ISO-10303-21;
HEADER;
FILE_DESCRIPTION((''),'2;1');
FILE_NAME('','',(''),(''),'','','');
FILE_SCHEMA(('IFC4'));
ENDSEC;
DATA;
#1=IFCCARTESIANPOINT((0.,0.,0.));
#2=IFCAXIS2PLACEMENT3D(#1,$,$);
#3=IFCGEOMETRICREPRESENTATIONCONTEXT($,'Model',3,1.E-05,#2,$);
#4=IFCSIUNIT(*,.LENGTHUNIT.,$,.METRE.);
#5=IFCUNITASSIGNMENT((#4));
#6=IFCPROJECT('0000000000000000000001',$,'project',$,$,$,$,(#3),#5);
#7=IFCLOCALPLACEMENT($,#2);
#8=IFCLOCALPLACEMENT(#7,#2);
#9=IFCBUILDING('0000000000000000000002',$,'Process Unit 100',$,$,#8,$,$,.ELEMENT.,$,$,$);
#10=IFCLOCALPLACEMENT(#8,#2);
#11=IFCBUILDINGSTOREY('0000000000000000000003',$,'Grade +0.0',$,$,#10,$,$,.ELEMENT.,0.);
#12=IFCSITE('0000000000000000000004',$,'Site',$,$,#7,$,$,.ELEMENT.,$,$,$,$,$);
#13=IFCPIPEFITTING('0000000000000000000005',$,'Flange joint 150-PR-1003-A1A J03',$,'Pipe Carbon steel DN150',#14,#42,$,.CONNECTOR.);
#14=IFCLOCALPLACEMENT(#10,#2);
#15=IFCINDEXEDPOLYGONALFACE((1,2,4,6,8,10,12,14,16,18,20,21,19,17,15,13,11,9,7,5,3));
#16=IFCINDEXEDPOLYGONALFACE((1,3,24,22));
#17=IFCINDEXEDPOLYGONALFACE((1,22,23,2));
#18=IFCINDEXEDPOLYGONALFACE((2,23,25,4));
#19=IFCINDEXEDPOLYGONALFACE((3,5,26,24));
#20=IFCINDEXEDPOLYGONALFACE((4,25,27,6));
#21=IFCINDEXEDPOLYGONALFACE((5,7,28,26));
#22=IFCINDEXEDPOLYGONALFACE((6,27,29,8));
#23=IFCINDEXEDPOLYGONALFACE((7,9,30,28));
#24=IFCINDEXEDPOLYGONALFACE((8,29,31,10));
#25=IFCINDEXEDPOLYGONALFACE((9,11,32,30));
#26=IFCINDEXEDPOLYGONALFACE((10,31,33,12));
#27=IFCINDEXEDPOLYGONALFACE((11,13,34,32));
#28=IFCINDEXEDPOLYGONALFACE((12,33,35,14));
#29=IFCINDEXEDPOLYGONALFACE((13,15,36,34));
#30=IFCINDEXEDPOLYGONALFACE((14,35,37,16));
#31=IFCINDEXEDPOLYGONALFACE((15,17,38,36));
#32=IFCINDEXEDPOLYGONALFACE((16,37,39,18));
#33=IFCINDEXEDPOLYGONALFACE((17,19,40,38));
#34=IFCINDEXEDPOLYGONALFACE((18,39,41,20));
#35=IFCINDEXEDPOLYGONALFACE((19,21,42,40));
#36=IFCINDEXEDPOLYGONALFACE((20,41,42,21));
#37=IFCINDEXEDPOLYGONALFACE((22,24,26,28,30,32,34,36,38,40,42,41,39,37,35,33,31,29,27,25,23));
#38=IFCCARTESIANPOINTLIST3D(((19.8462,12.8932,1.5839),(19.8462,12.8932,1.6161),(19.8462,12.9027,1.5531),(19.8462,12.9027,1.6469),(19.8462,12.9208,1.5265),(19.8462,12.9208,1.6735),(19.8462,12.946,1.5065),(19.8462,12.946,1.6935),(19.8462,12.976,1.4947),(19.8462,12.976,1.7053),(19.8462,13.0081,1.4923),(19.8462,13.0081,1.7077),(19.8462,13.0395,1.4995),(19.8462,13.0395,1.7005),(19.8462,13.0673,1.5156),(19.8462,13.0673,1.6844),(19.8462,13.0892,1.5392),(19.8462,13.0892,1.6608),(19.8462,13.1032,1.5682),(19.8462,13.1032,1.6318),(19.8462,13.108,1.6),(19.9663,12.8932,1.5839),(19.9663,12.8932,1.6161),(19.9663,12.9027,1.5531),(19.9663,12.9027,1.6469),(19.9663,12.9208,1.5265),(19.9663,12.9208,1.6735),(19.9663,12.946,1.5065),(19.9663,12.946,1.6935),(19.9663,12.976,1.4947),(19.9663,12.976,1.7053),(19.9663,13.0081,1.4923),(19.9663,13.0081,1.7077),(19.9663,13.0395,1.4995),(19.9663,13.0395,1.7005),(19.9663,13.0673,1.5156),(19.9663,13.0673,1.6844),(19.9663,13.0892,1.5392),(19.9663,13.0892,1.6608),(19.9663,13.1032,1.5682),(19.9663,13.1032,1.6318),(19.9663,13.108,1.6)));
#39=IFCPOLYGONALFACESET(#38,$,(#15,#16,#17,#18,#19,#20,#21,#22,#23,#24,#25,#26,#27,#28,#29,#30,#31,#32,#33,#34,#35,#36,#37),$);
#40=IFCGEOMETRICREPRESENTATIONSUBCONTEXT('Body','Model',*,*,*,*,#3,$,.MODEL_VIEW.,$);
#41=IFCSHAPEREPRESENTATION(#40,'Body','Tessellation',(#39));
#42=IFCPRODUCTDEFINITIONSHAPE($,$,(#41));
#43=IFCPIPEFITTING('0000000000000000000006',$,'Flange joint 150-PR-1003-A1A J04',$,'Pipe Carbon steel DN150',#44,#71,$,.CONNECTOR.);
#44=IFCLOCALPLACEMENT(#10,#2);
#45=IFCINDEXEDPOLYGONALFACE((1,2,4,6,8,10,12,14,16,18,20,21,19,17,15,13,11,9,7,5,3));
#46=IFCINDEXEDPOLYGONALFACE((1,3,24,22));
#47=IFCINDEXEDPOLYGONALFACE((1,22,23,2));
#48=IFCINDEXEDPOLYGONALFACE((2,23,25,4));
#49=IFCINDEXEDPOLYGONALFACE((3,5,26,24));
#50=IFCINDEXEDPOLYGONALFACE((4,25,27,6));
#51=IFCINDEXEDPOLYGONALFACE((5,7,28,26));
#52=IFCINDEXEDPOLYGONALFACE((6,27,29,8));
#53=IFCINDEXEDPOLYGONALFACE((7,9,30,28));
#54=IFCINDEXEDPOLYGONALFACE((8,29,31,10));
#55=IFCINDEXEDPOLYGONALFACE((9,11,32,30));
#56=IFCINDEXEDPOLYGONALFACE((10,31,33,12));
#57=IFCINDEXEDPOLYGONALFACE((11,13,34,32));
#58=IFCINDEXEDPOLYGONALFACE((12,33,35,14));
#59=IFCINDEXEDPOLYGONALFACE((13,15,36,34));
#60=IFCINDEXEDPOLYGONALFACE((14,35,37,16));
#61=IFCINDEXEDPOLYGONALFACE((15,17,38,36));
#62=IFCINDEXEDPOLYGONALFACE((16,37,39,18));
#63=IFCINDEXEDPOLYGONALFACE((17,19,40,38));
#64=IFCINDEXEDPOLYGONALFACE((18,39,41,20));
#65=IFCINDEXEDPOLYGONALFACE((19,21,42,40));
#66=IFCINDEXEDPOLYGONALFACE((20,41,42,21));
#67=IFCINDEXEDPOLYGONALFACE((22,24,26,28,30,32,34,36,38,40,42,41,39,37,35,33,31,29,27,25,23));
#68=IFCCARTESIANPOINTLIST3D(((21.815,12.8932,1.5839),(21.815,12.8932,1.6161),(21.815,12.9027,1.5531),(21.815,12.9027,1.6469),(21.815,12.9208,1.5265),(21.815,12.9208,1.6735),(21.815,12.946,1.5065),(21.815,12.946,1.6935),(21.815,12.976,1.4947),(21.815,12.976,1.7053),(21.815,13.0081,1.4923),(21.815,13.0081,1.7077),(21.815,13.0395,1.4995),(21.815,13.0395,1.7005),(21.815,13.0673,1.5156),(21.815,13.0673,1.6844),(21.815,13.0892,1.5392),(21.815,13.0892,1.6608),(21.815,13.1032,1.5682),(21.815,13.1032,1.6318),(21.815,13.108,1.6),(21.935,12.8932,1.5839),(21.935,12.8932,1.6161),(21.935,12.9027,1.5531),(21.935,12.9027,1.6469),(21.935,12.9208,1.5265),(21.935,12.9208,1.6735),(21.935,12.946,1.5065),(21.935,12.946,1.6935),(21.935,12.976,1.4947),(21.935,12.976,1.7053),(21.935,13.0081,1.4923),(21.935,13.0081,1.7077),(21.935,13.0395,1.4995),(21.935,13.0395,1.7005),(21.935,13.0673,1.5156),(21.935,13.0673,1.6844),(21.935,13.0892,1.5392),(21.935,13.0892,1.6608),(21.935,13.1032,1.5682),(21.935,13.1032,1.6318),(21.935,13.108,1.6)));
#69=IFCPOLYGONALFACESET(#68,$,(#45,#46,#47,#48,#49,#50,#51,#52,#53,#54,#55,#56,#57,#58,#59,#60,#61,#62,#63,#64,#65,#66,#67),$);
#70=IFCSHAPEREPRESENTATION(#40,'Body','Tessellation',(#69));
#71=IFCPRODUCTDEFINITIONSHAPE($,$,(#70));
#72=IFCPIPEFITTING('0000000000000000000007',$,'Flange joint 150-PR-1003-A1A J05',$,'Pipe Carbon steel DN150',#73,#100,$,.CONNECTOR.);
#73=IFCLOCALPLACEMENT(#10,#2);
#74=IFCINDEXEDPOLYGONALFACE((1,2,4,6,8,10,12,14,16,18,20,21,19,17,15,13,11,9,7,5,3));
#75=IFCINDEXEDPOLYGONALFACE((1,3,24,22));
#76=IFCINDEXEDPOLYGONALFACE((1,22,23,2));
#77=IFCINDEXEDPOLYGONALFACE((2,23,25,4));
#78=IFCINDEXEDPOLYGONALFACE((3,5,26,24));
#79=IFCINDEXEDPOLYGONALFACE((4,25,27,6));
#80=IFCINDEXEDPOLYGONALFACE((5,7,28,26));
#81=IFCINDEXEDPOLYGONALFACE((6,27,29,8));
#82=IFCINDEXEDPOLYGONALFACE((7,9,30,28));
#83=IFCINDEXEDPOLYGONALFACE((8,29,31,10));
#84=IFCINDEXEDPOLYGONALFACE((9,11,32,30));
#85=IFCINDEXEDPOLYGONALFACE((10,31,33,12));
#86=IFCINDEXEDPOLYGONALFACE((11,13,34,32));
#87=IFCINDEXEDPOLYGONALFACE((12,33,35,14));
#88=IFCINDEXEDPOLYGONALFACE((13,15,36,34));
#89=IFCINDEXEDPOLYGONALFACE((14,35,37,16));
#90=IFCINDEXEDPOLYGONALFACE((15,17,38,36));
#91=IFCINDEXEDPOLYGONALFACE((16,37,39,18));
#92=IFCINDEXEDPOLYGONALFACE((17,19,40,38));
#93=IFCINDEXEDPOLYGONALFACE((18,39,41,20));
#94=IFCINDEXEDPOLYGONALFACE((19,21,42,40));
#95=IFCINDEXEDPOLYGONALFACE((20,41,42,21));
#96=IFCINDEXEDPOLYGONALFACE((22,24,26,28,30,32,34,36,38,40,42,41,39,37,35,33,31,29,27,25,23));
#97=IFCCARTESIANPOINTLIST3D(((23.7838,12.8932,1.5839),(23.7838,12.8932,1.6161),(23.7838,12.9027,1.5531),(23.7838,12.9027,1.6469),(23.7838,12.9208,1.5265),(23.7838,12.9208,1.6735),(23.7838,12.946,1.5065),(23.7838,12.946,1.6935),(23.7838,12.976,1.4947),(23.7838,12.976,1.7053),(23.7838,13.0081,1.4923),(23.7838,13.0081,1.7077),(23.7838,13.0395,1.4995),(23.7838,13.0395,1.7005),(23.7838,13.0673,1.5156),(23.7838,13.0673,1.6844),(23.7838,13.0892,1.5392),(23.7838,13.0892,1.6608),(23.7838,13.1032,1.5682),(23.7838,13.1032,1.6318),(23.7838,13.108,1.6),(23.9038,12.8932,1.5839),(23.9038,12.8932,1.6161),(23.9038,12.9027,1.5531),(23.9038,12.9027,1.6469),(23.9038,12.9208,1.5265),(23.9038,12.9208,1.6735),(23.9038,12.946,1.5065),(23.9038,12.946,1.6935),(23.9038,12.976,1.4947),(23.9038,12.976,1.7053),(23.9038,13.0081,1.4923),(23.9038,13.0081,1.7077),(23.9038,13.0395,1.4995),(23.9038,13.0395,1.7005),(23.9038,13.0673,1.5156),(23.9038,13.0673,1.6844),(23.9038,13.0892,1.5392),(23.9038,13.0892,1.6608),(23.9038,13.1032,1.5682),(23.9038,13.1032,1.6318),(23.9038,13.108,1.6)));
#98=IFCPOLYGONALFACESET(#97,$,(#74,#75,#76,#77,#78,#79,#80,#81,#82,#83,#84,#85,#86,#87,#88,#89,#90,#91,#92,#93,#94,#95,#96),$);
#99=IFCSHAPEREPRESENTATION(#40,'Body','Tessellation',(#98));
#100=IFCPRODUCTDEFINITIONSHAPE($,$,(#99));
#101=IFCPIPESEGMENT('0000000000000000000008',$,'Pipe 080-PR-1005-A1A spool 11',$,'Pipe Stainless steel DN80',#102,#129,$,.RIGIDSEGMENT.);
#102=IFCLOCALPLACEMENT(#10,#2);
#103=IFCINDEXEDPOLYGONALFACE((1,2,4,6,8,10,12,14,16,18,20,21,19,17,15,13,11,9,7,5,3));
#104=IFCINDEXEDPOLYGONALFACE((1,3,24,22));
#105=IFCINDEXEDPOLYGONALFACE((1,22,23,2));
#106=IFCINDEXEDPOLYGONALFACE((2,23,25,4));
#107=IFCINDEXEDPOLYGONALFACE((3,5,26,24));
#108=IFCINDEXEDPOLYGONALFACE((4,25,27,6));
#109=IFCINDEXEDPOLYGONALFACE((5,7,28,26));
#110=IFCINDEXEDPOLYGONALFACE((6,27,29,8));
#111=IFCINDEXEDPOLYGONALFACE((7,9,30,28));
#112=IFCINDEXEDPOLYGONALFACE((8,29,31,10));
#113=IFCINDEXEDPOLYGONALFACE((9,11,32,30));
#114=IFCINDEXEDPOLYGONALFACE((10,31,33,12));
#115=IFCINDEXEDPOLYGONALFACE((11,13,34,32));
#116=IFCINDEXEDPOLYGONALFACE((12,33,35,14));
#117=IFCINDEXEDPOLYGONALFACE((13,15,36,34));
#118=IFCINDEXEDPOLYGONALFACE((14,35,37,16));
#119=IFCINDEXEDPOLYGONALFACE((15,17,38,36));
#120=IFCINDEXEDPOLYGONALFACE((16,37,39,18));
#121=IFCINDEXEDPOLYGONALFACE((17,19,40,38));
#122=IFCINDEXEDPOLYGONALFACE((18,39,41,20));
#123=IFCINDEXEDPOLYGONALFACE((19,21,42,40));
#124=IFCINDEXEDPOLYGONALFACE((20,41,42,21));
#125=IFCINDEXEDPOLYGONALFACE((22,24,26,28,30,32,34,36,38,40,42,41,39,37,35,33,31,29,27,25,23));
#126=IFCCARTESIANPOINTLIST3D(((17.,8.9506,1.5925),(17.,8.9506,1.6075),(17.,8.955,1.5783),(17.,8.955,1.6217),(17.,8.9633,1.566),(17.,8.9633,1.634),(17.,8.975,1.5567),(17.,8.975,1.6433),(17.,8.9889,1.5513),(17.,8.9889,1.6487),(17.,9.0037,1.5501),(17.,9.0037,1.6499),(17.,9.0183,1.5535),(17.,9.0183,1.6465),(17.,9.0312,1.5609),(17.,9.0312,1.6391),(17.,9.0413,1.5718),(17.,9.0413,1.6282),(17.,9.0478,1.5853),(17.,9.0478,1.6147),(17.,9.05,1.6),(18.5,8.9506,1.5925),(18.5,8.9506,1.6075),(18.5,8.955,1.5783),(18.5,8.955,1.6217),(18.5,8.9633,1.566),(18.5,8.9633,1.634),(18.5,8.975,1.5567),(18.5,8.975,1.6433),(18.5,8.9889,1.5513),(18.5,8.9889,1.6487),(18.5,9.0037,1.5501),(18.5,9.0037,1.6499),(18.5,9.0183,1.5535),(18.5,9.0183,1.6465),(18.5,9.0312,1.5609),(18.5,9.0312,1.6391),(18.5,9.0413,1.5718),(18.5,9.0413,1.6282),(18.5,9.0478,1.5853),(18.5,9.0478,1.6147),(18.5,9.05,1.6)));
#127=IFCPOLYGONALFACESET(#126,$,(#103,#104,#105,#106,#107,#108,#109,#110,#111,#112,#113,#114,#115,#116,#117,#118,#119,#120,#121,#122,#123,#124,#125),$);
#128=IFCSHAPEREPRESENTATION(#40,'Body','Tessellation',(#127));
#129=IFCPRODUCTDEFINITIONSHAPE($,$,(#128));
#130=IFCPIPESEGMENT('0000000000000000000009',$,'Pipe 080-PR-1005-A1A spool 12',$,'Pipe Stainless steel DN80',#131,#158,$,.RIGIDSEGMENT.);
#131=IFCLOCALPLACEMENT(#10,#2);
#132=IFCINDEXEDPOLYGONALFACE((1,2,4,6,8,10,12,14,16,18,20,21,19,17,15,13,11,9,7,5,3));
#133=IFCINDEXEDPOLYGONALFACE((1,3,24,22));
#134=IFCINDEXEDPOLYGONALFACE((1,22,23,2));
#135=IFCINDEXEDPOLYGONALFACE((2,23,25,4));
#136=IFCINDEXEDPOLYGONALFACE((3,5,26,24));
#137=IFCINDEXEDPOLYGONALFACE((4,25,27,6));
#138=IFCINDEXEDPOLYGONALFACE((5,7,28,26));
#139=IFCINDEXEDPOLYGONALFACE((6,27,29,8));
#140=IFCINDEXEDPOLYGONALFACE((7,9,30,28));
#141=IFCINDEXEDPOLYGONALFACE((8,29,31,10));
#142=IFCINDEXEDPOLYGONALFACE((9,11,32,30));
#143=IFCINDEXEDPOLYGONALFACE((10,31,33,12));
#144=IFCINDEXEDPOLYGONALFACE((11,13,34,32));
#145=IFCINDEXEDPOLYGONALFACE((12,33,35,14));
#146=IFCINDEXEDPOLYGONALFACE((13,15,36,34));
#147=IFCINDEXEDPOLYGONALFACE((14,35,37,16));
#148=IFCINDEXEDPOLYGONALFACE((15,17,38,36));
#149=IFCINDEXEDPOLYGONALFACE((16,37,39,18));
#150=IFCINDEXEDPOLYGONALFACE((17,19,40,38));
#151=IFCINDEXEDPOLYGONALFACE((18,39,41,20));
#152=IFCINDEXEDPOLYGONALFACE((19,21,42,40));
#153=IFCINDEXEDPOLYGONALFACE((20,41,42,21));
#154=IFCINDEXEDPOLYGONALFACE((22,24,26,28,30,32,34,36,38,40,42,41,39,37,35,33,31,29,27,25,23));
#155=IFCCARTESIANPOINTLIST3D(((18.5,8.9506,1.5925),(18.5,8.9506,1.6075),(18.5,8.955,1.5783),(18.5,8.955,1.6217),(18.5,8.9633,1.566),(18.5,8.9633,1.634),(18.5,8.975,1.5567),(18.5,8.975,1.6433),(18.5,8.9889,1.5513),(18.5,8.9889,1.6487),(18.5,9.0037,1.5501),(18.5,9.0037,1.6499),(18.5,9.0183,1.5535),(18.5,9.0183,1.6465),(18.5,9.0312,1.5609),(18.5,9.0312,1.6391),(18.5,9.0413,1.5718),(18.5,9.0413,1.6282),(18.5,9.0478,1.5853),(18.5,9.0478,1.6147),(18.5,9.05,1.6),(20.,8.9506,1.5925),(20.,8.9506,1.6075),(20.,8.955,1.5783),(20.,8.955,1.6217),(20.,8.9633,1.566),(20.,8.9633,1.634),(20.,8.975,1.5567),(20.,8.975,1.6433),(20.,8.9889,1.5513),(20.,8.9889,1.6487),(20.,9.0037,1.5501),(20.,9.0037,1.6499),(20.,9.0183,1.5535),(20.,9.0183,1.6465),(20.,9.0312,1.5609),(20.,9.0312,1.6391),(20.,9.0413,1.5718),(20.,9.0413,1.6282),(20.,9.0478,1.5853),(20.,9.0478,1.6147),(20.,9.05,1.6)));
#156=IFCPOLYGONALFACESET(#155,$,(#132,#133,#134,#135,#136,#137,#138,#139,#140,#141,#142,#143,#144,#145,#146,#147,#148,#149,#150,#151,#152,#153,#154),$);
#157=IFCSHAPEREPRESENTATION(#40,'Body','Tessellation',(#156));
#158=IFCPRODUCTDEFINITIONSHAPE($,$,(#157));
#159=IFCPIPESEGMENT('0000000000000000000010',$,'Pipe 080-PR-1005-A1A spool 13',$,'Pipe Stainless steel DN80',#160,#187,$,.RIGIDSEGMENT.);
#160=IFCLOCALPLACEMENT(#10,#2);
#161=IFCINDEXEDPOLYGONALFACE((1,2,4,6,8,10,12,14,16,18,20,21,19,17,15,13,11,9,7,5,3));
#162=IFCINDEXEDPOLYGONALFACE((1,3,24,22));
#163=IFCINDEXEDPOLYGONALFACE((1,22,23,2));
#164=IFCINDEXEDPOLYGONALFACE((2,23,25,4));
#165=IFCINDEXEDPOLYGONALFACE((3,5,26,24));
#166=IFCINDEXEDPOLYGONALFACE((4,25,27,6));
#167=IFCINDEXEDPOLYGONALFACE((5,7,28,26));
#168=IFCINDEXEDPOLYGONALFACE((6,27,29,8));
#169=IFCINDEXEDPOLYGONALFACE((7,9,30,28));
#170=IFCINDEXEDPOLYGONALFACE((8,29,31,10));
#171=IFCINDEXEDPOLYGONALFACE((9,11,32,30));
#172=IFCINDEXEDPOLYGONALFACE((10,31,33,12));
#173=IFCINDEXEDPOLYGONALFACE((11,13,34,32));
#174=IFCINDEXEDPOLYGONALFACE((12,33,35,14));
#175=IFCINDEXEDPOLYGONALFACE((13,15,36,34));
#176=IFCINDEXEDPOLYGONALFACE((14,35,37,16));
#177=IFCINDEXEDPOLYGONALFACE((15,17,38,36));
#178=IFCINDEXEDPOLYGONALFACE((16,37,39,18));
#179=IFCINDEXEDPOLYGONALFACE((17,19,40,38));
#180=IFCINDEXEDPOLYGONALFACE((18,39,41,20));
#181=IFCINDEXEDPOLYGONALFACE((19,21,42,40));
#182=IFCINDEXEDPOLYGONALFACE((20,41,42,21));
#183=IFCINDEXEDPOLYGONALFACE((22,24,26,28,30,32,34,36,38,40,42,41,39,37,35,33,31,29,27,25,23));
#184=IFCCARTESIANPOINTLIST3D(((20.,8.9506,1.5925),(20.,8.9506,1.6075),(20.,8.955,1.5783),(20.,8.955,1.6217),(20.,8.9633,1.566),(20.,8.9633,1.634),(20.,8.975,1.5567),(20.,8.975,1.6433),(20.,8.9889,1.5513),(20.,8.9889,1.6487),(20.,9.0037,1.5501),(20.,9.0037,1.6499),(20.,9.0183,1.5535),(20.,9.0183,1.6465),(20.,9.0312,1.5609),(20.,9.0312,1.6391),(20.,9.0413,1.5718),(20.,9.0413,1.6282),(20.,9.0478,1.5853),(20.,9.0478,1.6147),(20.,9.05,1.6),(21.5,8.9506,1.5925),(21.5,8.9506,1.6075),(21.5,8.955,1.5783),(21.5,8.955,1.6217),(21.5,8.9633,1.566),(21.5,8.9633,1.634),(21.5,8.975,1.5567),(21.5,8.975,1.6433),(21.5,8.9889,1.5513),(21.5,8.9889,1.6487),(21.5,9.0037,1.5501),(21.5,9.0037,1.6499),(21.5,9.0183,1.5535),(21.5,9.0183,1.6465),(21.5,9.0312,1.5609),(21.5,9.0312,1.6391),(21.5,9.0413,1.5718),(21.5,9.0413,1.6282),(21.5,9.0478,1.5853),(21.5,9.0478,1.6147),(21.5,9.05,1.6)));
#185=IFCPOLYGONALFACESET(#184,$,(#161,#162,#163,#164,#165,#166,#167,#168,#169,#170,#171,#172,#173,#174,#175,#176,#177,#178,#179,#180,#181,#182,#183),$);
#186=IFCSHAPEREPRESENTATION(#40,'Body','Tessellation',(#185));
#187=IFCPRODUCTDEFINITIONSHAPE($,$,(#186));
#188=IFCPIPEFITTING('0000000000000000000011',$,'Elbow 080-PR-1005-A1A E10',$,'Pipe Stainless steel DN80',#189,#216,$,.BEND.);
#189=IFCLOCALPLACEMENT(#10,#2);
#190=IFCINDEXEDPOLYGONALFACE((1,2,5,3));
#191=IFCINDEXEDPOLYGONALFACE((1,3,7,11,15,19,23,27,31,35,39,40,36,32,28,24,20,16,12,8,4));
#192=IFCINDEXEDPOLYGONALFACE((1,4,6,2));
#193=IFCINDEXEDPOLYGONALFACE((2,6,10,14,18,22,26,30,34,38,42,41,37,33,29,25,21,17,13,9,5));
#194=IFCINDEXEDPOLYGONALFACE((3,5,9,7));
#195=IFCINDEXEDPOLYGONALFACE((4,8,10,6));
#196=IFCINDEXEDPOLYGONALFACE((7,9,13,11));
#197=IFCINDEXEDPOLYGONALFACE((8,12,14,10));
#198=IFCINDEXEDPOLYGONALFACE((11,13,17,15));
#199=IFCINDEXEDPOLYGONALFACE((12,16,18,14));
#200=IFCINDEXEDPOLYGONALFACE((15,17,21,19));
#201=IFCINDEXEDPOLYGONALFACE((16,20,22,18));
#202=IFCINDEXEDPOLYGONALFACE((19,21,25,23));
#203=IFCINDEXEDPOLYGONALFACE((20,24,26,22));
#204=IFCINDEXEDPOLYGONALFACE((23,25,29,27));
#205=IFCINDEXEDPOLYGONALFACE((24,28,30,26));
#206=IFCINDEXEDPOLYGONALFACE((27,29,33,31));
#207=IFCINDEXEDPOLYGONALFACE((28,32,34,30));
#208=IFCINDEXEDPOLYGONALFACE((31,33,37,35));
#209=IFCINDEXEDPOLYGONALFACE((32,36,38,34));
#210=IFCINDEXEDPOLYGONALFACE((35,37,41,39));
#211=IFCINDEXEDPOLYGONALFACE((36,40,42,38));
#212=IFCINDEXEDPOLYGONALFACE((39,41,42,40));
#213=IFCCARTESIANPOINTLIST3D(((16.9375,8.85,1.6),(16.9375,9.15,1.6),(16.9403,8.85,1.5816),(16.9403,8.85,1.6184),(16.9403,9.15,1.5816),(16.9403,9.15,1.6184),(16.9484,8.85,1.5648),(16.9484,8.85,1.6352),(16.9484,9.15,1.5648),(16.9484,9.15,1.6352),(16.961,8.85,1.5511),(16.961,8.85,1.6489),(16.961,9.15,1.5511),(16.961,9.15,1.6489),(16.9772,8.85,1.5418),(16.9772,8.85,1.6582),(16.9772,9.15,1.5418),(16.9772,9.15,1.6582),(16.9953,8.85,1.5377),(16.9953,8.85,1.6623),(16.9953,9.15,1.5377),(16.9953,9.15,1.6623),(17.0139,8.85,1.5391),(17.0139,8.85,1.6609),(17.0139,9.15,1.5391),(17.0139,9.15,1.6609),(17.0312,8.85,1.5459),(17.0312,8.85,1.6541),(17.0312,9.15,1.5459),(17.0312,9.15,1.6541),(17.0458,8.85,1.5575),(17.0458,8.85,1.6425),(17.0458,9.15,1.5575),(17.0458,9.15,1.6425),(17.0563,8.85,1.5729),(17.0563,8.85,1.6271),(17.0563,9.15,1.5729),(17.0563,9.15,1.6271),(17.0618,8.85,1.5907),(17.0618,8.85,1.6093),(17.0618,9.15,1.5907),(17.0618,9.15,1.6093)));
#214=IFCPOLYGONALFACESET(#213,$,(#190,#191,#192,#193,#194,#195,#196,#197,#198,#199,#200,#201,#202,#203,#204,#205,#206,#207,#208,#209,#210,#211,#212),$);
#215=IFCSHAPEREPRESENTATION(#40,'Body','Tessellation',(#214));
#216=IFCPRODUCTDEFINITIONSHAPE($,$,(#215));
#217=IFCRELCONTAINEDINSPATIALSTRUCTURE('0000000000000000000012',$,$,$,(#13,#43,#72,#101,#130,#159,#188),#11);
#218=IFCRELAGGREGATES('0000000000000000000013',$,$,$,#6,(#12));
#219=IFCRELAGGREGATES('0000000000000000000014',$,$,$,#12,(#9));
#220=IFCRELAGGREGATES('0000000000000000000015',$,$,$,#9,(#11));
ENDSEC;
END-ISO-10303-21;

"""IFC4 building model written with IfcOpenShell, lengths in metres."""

from ifc_helpers import new_model, si_unit, frame, origin, place, context, subcontext, project, spatial, circle, extrude, element, save


model = new_model("IFC4")

# Units and contexts
model_context = context("Model", 3, precision=1e-05, world=origin())
body_context = subcontext(model_context, "Body", "Model", "MODEL_VIEW")
ifc_project = project(units=[si_unit("LENGTHUNIT", "METRE")], contexts=[model_context])

# Site, building, storey
site_placement = place(None, origin())
site = spatial("IfcSite", under=ifc_project, at=site_placement, Name="Site", CompositionType="ELEMENT")
building_placement = place(site_placement, origin())
building = spatial("IfcBuilding", under=site, at=building_placement, Name="Process Unit 100", CompositionType="ELEMENT")
storey_placement = place(building_placement, origin())
storey = spatial("IfcBuildingStorey", under=building, at=storey_placement, Name="Grade +0.0", CompositionType="ELEMENT", Elevation=0.0)

# Pipe fittings
for number, where, z_axis, x_axis, name in (
    (1, (19.8463, 13.0, 1.6), (1.0, 0.0, 0.0), (0.0, 1.0, 0.0), "Flange joint 150-PR-1003-A1A J03"),
    (2, (21.815, 13.0, 1.6), (1.0, 0.0, 0.0), (0.0, 1.0, 0.0), "Flange joint 150-PR-1003-A1A J04"),
    (3, (23.7838, 13.0, 1.6), (1.0, 0.0, 0.0), (0.0, 1.0, 0.0), "Flange joint 150-PR-1003-A1A J05"),
):
    element("IfcPipeFitting", number, at=place(storey_placement, frame(where, z_axis=z_axis, x_axis=x_axis)), inside=storey, Name=name, ObjectType="Pipe Carbon steel DN150", PredefinedType="CONNECTOR", context=body_context, shape_type="SweptSolid", body=[
        extrude(circle(Radius=0.108), origin(), (0.0, 0.0, 1.0), 0.12),
    ])

# Pipe segments
for number, where, z_axis, x_axis, name in (
    (4, (17.0, 9.0, 1.6), (1.0, 0.0, 0.0), (0.0, 1.0, 0.0), "Pipe 080-PR-1005-A1A spool 11"),
    (5, (18.5, 9.0, 1.6), (1.0, 0.0, 0.0), (0.0, 1.0, 0.0), "Pipe 080-PR-1005-A1A spool 12"),
    (6, (20.0, 9.0, 1.6), (1.0, 0.0, 0.0), (0.0, 1.0, 0.0), "Pipe 080-PR-1005-A1A spool 13"),
):
    element("IfcPipeSegment", number, at=place(storey_placement, frame(where, z_axis=z_axis, x_axis=x_axis)), inside=storey, Name=name, ObjectType="Pipe Stainless steel DN80", PredefinedType="RIGIDSEGMENT", context=body_context, shape_type="SweptSolid", body=[
        extrude(circle(Radius=0.05), origin(), (0.0, 0.0, 1.0), 1.5),
    ])

# Pipe fitting
pipe_fitting_1_placement = place(storey_placement, frame((17.0, 8.85, 1.6), z_axis=(0.0, 1.0, 0.0), x_axis=(-1.0, 0.0, 0.0)))
element("IfcPipeFitting", 7, at=pipe_fitting_1_placement, inside=storey, Name="Elbow 080-PR-1005-A1A E10", ObjectType="Pipe Stainless steel DN80", PredefinedType="BEND", context=body_context, shape_type="SweptSolid", body=[
    extrude(circle(Radius=0.0625), origin(), (0.0, 0.0, 1.0), 0.3),
])

save(model, "model.ifc")
